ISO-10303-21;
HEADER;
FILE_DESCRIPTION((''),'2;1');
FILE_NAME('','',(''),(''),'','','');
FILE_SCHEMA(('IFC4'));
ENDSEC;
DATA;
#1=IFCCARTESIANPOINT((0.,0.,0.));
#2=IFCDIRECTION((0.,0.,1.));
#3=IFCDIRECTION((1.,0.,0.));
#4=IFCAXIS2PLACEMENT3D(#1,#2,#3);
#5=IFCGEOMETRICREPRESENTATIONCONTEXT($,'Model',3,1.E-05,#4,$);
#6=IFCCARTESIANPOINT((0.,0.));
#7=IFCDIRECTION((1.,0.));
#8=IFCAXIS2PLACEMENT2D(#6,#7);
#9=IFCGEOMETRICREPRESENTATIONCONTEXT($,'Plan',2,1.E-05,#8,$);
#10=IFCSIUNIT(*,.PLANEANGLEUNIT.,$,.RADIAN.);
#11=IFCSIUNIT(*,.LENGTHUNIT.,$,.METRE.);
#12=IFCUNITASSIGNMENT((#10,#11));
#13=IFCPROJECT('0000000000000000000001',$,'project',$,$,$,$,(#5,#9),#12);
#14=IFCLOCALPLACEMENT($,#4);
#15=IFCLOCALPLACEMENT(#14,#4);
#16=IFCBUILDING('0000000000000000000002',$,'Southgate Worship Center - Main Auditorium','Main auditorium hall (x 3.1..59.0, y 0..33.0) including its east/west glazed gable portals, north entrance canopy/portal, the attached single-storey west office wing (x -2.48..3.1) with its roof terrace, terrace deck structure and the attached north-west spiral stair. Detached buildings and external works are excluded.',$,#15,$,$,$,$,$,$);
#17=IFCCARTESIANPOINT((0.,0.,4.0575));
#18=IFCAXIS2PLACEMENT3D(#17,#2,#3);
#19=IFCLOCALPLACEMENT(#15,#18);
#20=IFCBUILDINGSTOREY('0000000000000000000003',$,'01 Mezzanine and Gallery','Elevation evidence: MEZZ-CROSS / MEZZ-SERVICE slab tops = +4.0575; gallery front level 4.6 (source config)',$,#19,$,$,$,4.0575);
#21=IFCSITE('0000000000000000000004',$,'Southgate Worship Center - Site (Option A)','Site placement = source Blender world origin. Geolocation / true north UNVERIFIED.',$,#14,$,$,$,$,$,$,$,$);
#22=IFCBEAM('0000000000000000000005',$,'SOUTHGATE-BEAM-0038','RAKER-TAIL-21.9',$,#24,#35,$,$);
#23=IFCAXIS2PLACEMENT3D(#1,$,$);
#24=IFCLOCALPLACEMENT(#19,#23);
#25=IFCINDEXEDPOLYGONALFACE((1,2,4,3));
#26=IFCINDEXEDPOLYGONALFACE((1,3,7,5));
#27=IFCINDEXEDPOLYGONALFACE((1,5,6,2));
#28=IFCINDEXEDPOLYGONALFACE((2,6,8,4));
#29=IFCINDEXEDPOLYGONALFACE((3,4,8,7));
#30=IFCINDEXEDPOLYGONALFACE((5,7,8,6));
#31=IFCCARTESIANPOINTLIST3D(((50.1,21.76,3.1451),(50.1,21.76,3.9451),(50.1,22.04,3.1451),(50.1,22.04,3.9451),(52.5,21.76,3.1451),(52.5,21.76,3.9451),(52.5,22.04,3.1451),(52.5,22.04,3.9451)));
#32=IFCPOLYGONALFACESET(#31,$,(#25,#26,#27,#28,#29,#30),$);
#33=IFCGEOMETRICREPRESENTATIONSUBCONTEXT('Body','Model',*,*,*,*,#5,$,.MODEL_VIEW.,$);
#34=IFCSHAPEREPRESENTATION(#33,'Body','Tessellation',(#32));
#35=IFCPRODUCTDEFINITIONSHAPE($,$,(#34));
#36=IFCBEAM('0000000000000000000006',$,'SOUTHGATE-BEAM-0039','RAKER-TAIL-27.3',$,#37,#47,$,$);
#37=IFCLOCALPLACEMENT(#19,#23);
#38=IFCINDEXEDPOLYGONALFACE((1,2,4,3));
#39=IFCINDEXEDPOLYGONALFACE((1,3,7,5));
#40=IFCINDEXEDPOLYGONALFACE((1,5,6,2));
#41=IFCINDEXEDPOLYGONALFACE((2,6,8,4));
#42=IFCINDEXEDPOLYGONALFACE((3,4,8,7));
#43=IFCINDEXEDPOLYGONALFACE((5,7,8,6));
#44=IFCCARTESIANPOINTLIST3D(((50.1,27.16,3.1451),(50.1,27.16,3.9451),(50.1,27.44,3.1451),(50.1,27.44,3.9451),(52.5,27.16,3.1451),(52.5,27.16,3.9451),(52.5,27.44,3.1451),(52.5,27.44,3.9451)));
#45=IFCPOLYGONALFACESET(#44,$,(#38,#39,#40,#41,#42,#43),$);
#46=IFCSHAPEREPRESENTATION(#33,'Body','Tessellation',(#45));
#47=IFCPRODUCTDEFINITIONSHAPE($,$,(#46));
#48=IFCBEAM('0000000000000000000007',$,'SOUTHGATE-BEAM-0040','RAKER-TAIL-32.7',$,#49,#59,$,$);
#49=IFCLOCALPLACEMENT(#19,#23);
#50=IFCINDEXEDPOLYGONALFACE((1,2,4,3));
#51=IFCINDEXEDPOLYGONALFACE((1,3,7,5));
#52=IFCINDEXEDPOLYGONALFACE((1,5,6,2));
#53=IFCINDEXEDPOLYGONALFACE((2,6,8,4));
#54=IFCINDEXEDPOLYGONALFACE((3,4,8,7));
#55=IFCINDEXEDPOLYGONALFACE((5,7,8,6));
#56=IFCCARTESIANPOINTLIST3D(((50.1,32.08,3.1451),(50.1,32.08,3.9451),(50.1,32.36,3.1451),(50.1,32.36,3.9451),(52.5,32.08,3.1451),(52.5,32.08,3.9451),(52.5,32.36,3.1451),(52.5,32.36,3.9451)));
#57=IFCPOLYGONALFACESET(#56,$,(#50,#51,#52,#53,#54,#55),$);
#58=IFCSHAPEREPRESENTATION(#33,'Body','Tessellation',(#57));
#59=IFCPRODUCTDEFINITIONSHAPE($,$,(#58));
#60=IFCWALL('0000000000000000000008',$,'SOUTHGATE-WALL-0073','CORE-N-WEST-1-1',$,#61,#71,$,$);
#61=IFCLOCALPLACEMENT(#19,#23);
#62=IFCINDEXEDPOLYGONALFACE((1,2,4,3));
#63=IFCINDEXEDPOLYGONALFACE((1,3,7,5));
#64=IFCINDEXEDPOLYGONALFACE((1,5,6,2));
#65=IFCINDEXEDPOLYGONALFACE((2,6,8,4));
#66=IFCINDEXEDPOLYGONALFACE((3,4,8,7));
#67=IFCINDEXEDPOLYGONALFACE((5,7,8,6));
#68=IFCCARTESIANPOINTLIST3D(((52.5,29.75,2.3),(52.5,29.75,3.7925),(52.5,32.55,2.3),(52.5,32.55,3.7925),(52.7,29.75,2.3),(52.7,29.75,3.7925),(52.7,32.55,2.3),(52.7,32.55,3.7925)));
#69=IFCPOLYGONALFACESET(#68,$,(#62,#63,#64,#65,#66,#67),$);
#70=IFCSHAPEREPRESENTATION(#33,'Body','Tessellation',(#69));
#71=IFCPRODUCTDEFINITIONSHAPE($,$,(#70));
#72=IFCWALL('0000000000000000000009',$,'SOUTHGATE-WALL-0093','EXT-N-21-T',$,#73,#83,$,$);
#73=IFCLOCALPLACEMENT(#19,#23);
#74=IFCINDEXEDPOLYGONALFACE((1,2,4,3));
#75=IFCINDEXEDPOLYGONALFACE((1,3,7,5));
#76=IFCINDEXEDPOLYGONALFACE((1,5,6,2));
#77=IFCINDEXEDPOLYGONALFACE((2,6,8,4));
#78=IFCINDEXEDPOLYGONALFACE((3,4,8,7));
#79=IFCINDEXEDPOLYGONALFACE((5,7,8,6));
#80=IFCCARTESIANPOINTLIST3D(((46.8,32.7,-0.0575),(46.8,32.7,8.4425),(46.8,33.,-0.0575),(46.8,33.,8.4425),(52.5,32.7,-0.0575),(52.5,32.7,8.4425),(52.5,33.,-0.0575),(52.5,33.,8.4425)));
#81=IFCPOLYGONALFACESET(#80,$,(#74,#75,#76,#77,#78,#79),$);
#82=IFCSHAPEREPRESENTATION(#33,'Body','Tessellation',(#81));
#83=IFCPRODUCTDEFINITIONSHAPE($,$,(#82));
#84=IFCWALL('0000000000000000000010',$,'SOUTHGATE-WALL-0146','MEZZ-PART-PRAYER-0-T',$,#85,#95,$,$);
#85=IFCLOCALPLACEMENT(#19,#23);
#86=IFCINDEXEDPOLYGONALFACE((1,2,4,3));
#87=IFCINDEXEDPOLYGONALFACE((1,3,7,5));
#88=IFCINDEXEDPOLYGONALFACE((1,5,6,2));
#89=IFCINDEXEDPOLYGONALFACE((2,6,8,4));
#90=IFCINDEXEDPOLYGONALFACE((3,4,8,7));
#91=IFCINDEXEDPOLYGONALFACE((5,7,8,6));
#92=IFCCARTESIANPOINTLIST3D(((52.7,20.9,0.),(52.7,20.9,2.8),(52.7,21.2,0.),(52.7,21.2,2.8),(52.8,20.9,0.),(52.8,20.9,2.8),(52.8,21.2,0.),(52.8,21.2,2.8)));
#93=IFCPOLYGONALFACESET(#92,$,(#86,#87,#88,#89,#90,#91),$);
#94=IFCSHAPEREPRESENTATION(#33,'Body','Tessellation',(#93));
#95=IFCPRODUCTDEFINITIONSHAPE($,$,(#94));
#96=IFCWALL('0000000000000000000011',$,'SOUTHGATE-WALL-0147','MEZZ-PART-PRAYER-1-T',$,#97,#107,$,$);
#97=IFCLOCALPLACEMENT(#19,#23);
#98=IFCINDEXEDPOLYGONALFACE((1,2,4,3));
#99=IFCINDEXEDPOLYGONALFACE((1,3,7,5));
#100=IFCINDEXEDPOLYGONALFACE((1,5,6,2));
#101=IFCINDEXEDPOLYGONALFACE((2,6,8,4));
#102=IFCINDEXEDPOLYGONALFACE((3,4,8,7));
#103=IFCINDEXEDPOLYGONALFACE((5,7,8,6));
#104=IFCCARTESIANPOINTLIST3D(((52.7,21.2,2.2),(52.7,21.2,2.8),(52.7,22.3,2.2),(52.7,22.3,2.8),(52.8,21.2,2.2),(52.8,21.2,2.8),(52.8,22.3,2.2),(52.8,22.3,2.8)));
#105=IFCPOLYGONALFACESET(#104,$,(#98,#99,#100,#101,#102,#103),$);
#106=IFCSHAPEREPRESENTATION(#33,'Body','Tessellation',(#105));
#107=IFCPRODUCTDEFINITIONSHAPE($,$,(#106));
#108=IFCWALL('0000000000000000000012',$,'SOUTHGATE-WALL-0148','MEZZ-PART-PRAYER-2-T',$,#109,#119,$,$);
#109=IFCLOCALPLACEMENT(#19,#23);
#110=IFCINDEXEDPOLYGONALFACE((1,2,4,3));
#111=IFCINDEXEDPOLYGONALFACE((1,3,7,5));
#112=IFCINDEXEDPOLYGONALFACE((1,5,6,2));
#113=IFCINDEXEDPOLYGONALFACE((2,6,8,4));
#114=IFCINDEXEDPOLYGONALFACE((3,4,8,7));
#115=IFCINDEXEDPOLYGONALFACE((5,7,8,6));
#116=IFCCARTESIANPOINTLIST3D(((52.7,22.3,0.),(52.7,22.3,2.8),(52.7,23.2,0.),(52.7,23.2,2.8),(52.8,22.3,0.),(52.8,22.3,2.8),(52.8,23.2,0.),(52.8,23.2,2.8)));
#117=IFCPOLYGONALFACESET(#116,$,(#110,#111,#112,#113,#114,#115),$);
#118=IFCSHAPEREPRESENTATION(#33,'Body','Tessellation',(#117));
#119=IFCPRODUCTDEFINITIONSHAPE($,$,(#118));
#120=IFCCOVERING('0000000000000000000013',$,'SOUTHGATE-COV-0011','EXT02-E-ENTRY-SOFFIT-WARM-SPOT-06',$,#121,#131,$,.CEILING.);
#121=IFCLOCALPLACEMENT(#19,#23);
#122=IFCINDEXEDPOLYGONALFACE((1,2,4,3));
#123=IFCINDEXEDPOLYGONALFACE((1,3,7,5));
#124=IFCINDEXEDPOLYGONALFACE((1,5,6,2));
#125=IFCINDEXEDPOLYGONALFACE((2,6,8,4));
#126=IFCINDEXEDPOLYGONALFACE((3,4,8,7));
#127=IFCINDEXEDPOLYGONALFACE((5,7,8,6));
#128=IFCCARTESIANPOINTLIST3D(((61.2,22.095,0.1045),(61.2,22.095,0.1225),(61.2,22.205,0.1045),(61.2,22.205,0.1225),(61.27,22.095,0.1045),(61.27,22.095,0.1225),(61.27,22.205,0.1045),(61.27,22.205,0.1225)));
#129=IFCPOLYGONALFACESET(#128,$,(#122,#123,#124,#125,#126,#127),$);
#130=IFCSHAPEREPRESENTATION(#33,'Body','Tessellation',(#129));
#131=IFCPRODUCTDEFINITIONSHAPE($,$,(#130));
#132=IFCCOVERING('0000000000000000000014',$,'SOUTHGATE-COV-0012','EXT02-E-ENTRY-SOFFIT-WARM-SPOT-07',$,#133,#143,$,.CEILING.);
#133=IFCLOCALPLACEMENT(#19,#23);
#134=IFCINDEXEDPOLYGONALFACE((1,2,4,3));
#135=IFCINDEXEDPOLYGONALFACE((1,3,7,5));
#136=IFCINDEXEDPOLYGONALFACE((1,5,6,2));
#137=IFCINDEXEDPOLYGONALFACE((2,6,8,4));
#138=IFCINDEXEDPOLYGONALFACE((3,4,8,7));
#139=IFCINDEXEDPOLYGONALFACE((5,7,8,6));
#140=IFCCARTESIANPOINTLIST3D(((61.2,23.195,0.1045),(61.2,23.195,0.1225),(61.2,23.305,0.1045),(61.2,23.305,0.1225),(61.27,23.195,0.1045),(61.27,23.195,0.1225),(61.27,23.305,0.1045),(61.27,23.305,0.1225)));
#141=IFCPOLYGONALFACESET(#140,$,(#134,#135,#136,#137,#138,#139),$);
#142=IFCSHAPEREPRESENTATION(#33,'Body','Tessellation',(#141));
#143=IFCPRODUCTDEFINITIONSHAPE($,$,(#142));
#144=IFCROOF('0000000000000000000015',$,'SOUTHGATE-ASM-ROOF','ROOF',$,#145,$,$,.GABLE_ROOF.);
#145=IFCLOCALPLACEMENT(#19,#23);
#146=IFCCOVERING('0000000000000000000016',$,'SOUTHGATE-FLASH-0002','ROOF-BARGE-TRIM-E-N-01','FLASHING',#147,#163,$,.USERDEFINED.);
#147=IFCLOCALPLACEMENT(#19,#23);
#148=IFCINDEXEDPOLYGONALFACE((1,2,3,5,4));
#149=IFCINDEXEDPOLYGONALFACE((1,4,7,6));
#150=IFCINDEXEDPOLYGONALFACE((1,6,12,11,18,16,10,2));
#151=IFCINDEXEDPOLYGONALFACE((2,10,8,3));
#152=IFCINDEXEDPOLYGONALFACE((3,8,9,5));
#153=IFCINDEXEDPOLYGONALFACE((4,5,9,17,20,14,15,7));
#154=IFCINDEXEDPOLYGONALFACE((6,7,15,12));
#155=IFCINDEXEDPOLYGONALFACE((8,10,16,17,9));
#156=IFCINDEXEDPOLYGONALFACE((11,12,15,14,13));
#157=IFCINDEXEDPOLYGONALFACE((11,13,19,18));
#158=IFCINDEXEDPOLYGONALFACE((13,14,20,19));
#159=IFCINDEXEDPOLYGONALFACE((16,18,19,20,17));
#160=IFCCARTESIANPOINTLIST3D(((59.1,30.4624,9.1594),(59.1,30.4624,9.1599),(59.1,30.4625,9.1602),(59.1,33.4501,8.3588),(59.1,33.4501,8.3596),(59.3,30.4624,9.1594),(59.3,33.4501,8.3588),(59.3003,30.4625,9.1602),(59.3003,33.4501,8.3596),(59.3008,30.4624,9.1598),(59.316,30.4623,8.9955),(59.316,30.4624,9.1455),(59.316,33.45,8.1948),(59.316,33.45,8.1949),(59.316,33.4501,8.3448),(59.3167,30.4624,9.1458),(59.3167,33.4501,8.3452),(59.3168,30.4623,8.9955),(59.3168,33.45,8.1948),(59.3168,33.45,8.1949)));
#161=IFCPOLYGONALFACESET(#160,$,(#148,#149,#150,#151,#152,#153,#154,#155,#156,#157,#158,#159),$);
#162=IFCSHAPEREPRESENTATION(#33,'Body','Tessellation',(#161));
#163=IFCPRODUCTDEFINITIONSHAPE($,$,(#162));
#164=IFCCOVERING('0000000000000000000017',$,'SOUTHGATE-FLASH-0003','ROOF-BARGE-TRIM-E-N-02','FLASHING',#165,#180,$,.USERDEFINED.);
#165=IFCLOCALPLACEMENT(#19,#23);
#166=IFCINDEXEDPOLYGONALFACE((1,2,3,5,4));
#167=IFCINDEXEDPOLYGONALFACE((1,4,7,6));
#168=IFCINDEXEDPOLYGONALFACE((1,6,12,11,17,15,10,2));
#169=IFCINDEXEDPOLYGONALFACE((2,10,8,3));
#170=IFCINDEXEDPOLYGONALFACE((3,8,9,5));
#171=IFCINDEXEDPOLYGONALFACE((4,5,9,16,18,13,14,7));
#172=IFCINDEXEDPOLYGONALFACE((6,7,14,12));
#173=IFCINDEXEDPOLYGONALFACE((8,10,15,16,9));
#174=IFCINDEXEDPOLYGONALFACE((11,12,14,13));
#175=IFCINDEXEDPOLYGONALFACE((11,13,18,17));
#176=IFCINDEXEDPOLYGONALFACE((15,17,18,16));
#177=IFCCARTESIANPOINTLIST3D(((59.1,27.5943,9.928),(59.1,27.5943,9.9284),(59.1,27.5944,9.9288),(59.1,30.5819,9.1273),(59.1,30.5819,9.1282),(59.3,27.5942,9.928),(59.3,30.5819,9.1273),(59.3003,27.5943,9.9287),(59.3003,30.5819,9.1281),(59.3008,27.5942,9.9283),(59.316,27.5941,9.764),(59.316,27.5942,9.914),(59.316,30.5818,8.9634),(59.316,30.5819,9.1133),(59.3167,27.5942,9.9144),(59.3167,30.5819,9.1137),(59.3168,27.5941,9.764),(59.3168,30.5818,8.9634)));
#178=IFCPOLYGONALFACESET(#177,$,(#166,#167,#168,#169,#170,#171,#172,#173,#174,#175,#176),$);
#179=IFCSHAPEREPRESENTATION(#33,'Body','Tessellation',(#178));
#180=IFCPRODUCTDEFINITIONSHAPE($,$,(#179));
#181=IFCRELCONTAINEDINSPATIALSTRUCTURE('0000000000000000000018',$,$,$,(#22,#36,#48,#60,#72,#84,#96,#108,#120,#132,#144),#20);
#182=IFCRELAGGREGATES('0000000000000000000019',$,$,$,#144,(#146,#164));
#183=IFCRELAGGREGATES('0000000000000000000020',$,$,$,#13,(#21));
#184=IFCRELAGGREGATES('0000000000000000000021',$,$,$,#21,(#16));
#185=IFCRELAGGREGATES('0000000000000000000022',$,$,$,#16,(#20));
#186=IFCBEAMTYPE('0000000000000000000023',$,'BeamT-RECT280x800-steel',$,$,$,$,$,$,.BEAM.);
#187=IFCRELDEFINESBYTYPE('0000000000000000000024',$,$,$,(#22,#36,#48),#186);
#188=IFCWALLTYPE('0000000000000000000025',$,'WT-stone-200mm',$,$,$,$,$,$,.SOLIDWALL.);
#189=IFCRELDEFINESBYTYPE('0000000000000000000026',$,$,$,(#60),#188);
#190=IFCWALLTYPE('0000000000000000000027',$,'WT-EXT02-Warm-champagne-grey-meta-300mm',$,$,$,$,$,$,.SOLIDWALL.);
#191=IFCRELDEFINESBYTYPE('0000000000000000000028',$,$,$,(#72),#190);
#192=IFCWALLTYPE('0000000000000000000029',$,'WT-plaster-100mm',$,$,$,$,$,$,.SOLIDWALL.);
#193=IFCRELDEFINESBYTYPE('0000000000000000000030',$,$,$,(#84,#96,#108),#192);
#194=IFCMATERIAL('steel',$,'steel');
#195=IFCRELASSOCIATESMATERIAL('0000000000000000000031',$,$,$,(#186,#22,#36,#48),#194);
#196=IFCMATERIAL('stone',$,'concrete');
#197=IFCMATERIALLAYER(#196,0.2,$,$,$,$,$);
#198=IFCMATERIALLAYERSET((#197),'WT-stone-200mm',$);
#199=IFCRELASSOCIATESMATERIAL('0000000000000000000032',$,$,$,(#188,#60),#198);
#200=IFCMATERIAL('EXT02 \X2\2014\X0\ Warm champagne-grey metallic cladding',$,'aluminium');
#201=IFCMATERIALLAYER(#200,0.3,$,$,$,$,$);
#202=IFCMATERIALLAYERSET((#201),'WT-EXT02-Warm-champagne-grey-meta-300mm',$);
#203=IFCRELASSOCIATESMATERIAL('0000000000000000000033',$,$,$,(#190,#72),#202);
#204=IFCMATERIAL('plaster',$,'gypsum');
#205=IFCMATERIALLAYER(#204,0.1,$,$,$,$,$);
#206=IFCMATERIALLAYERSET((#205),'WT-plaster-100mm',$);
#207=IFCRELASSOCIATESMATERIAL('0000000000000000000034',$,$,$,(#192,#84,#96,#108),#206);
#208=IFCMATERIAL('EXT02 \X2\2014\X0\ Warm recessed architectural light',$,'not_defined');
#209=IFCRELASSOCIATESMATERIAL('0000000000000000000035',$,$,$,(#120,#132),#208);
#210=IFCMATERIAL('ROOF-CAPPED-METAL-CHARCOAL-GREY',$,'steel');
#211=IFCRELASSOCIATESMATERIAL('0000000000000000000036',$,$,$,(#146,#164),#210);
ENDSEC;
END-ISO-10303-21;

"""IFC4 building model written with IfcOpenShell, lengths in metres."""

from ifc_helpers import new_model, si_unit, frame, origin_with_axes, origin_2d, origin_2d_with_axis, place, context, subcontext, project, spatial, indexed_curve, rectangle, outline, extrude, clip, halfspace, material, layer, layer_set, layer_usage, material_profile, profile_set, profile_usage, type_object, element, aggregate, save


model = new_model("IFC4")

# Units and contexts
model_context = context("Model", 3, precision=1e-05, world=origin_with_axes())
plan_context = context("Plan", 2, precision=1e-05, world=origin_2d_with_axis())
body_context = subcontext(model_context, "Body", "Model", "MODEL_VIEW")
ifc_project = project(units=[si_unit("PLANEANGLEUNIT", "RADIAN"), si_unit("LENGTHUNIT", "METRE")], contexts=[model_context, plan_context])

# Site, building, storey
site_placement = place(None, origin_with_axes())
site = spatial("IfcSite", under=ifc_project, at=site_placement, Name="Southgate Worship Center - Site (Option A)", Description="Site placement = source Blender world origin. Geolocation / true north UNVERIFIED.")
building_placement = place(site_placement, origin_with_axes())
building = spatial("IfcBuilding", under=site, at=building_placement, Name="Southgate Worship Center - Main Auditorium", Description="Main auditorium hall (x 3.1..59.0, y 0..33.0) including its east/west glazed gable portals, north entrance canopy/portal, the attached single-storey west office wing (x -2.48..3.1) with its roof terrace, terrace deck structure and the attached north-west spiral stair. Detached buildings and external works are excluded.")
storey_placement = place(building_placement, frame((0.0, 0.0, 4.0575), z_axis=(0.0, 0.0, 1.0), x_axis=(1.0, 0.0, 0.0)))
storey = spatial("IfcBuildingStorey", under=building, at=storey_placement, Name="01 Mezzanine and Gallery", Description="Elevation evidence: MEZZ-CROSS / MEZZ-SERVICE slab tops = +4.0575; gallery front level 4.6 (source config)", Elevation=4.0575)

# Beams
ifc_material_1 = material(Name="steel", Category="steel")
ifc_material_profile = material_profile(ifc_material_1, rectangle(XDim=0.28, YDim=0.8, at=origin_2d()))
ifc_profile_set = profile_set([ifc_material_profile], Name="BeamT-RECT280x800-steel")
ifc_profile_usage = profile_usage(ifc_profile_set)
beam_type = type_object("IfcBeamType", Name="BeamT-RECT280x800-steel", PredefinedType="BEAM", material=ifc_profile_set)
for number, where, z_axis, x_axis, name, description in (
    (1, (50.1, 21.9, 3.5451), (1.0, 0.0, 0.0), (0.0, -1.0, 0.0), "SOUTHGATE-BEAM-0038", "RAKER-TAIL-21.9"),
    (2, (50.1, 27.3, 3.5451), (1.0, 0.0, 0.0), (0.0, -1.0, 0.0), "SOUTHGATE-BEAM-0039", "RAKER-TAIL-27.3"),
    (3, (50.1, 32.22, 3.5451), (1.0, 0.0, 0.0), (0.0, -1.0, 0.0), "SOUTHGATE-BEAM-0040", "RAKER-TAIL-32.7"),
):
    element("IfcBeam", number, at=place(storey_placement, frame(where, z_axis=z_axis, x_axis=x_axis)), inside=storey, type_object=beam_type, material=ifc_profile_usage, Name=name, Description=description, context=body_context, shape_type="SweptSolid", body=[
        extrude(rectangle(XDim=0.28, YDim=0.8, at=origin_2d()), origin_with_axes(), (0.0, 0.0, 1.0), 2.4),
    ])

# Walls
ifc_material_2 = material(Name="stone", Category="concrete")
ifc_layer_1 = layer(ifc_material_2, 0.2)
ifc_layer_set_1 = layer_set([ifc_layer_1], Name="WT-stone-200mm")
ifc_layer_usage_1 = layer_usage(ifc_layer_set_1, "AXIS2", "POSITIVE", 0.0)
wall_type_1 = type_object("IfcWallType", Name="WT-stone-200mm", PredefinedType="SOLIDWALL", material=ifc_layer_set_1)
wall_1_placement = place(storey_placement, frame((52.7, 29.75, 2.3), z_axis=(0.0, 0.0, 1.0), x_axis=(0.0, 1.0, 0.0)))
element("IfcWall", 4, at=wall_1_placement, inside=storey, type_object=wall_type_1, material=ifc_layer_usage_1, Name="SOUTHGATE-WALL-0073", Description="CORE-N-WEST-1-1", context=body_context, shape_type="SweptSolid", body=[
    extrude(outline(indexed_curve([(0.0, 0.0), (0.0, 0.2), (2.8, 0.2), (2.8, 0.0), (0.0, 0.0)], self_intersect=False)), origin_with_axes(), (0.0, 0.0, 1.0), 1.4925),
])
ifc_material_3 = material(Name="EXT02 — Warm champagne-grey metallic cladding", Category="aluminium")
ifc_layer_2 = layer(ifc_material_3, 0.3)
ifc_layer_set_2 = layer_set([ifc_layer_2], Name="WT-EXT02-Warm-champagne-grey-meta-300mm")
ifc_layer_usage_2 = layer_usage(ifc_layer_set_2, "AXIS2", "POSITIVE", 0.0)
wall_type_2 = type_object("IfcWallType", Name="WT-EXT02-Warm-champagne-grey-meta-300mm", PredefinedType="SOLIDWALL", material=ifc_layer_set_2)
wall_2_placement = place(storey_placement, frame((52.5, 33.0, -0.0575), z_axis=(0.0, 0.0, 1.0), x_axis=(-1.0, 0.0, 0.0)))
element("IfcWall", 5, at=wall_2_placement, inside=storey, type_object=wall_type_2, material=ifc_layer_usage_2, Name="SOUTHGATE-WALL-0093", Description="EXT-N-21-T", context=body_context, shape_type="SweptSolid", body=[
    extrude(outline(indexed_curve([(0.0, 0.0), (0.0, 0.3), (5.7, 0.3), (5.7, 0.0), (0.0, 0.0)], self_intersect=False)), origin_with_axes(), (0.0, 0.0, 1.0), 8.5),
])
ifc_material_4 = material(Name="plaster", Category="gypsum")
ifc_layer_3 = layer(ifc_material_4, 0.1)
ifc_layer_set_3 = layer_set([ifc_layer_3], Name="WT-plaster-100mm")
ifc_layer_usage_3 = layer_usage(ifc_layer_set_3, "AXIS2", "POSITIVE", 0.0)
wall_type_3 = type_object("IfcWallType", Name="WT-plaster-100mm", PredefinedType="SOLIDWALL", material=ifc_layer_set_3)
wall_3_placement = place(storey_placement, frame((52.8, 20.9, 0.0), z_axis=(0.0, 0.0, 1.0), x_axis=(0.0, 1.0, 0.0)))
element("IfcWall", 6, at=wall_3_placement, inside=storey, type_object=wall_type_3, material=ifc_layer_usage_3, Name="SOUTHGATE-WALL-0146", Description="MEZZ-PART-PRAYER-0-T", context=body_context, shape_type="SweptSolid", body=[
    extrude(outline(indexed_curve([(0.0, 0.0), (0.0, 0.1), (0.3, 0.1), (0.3, 0.0), (0.0, 0.0)], self_intersect=False)), origin_with_axes(), (0.0, 0.0, 1.0), 2.8),
])
wall_4_placement = place(storey_placement, frame((52.8, 21.2, 2.2), z_axis=(0.0, 0.0, 1.0), x_axis=(0.0, 1.0, 0.0)))
element("IfcWall", 7, at=wall_4_placement, inside=storey, type_object=wall_type_3, material=ifc_layer_usage_3, Name="SOUTHGATE-WALL-0147", Description="MEZZ-PART-PRAYER-1-T", context=body_context, shape_type="SweptSolid", body=[
    extrude(outline(indexed_curve([(0.0, 0.0), (0.0, 0.1), (1.1, 0.1), (1.1, 0.0), (0.0, 0.0)], self_intersect=False)), origin_with_axes(), (0.0, 0.0, 1.0), 0.6),
])
wall_5_placement = place(storey_placement, frame((52.8, 22.3, 0.0), z_axis=(0.0, 0.0, 1.0), x_axis=(0.0, 1.0, 0.0)))
element("IfcWall", 8, at=wall_5_placement, inside=storey, type_object=wall_type_3, material=ifc_layer_usage_3, Name="SOUTHGATE-WALL-0148", Description="MEZZ-PART-PRAYER-2-T", context=body_context, shape_type="SweptSolid", body=[
    extrude(outline(indexed_curve([(0.0, 0.0), (0.0, 0.1), (0.9, 0.1), (0.9, 0.0), (0.0, 0.0)], self_intersect=False)), origin_with_axes(), (0.0, 0.0, 1.0), 2.8),
])

# Coverings
ifc_material_5 = material(Name="EXT02 — Warm recessed architectural light", Category="not_defined")
covering_1_placement = place(storey_placement, frame((61.2, 22.095, 0.1045), z_axis=(0.0, 0.0, 1.0), x_axis=(1.0, 0.0, 0.0)))
element("IfcCovering", 9, at=covering_1_placement, inside=storey, material=ifc_material_5, Name="SOUTHGATE-COV-0011", Description="EXT02-E-ENTRY-SOFFIT-WARM-SPOT-06", PredefinedType="CEILING", context=body_context, shape_type="SweptSolid", body=[
    extrude(rectangle(XDim=0.07, YDim=0.11, at=origin_2d()), frame((0.035, 0.055, 0.0), z_axis=(0.0, 0.0, 1.0), x_axis=(1.0, 0.0, 0.0)), (0.0, 0.0, 1.0), 0.018),
])
covering_2_placement = place(storey_placement, frame((61.2, 23.195, 0.1045), z_axis=(0.0, 0.0, 1.0), x_axis=(1.0, 0.0, 0.0)))
element("IfcCovering", 10, at=covering_2_placement, inside=storey, material=ifc_material_5, Name="SOUTHGATE-COV-0012", Description="EXT02-E-ENTRY-SOFFIT-WARM-SPOT-07", PredefinedType="CEILING", context=body_context, shape_type="SweptSolid", body=[
    extrude(rectangle(XDim=0.07, YDim=0.11, at=origin_2d()), frame((0.035, 0.055, 0.0), z_axis=(0.0, 0.0, 1.0), x_axis=(1.0, 0.0, 0.0)), (0.0, 0.0, 1.0), 0.018),
])

# Roof, coverings
roof_placement = place(storey_placement, origin_with_axes())
roof = element("IfcRoof", 11, at=roof_placement, inside=storey, Name="SOUTHGATE-ASM-ROOF", Description="ROOF", PredefinedType="GABLE_ROOF")
ifc_material_6 = material(Name="ROOF-CAPPED-METAL-CHARCOAL-GREY", Category="steel")
covering_3_placement = place(roof_placement, frame((59.1, 30.4623, 8.1949), z_axis=(0.0, 0.0, 1.0), x_axis=(1.0, 0.0, 0.0)))
covering_3 = element("IfcCovering", 12, at=covering_3_placement, material=ifc_material_6, Name="SOUTHGATE-FLASH-0002", Description="ROOF-BARGE-TRIM-E-N-01", ObjectType="FLASHING", PredefinedType="USERDEFINED", context=body_context, shape_type="Clipping", body=[
    clip(clip(extrude(outline(indexed_curve([(0.0, 0.0), (-0.0164, -0.0139), (-0.0165, -0.1592), (-0.0157, -0.1592), (-0.0157, -0.0143), (0.0003, -0.0008), (0.2003, -0.0008), (0.2003, 0.0), (0.0, 0.0)], self_intersect=False)), frame((0.2003, 0.0002, 0.9653), z_axis=(0.000014, 0.965918, -0.258848), x_axis=(-1.0, 0.000014, 0.0)), (0.0, 0.0, 1.0), 3.1355), halfspace(frame((0.1582, 0.0001, 0.9203), z_axis=(-0.000132, -1.0, 0.000481), x_axis=(1.0, -0.000132, 0.0)), False)), halfspace(frame((0.1582, 2.9878, 0.1197), z_axis=(0.00016, 1.0, -0.000443), x_axis=(-1.0, 0.00016, 0.0)), False)),
])
covering_4_placement = place(roof_placement, frame((59.1, 27.5941, 8.9634), z_axis=(0.0, 0.0, 1.0), x_axis=(1.0, 0.0, 0.0)))
covering_4 = element("IfcCovering", 13, at=covering_4_placement, material=ifc_material_6, Name="SOUTHGATE-FLASH-0003", Description="ROOF-BARGE-TRIM-E-N-02", ObjectType="FLASHING", PredefinedType="USERDEFINED", context=body_context, shape_type="Clipping", body=[
    clip(clip(extrude(outline(indexed_curve([(0.0, 0.0), (-0.0164, -0.0139), (-0.0165, -0.1592), (-0.0157, -0.1592), (-0.0157, -0.0143), (0.0003, -0.0008), (0.2003, -0.0008), (0.2003, 0.0), (0.0, 0.0)], self_intersect=False)), frame((0.2003, 0.0002, 0.9653), z_axis=(0.000014, 0.965918, -0.258848), x_axis=(-1.0, 0.000014, 0.0)), (0.0, 0.0, 1.0), 3.1355), halfspace(frame((0.1582, 0.0001, 0.9203), z_axis=(-0.000132, -1.0, 0.000481), x_axis=(1.0, -0.000132, 0.0)), False)), halfspace(frame((0.1582, 2.9878, 0.1198), z_axis=(0.000167, 1.0, -0.000439), x_axis=(-1.0, 0.000167, 0.0)), False)),
])
aggregate(roof, [covering_3, covering_4])

save(model, "model.ifc")
